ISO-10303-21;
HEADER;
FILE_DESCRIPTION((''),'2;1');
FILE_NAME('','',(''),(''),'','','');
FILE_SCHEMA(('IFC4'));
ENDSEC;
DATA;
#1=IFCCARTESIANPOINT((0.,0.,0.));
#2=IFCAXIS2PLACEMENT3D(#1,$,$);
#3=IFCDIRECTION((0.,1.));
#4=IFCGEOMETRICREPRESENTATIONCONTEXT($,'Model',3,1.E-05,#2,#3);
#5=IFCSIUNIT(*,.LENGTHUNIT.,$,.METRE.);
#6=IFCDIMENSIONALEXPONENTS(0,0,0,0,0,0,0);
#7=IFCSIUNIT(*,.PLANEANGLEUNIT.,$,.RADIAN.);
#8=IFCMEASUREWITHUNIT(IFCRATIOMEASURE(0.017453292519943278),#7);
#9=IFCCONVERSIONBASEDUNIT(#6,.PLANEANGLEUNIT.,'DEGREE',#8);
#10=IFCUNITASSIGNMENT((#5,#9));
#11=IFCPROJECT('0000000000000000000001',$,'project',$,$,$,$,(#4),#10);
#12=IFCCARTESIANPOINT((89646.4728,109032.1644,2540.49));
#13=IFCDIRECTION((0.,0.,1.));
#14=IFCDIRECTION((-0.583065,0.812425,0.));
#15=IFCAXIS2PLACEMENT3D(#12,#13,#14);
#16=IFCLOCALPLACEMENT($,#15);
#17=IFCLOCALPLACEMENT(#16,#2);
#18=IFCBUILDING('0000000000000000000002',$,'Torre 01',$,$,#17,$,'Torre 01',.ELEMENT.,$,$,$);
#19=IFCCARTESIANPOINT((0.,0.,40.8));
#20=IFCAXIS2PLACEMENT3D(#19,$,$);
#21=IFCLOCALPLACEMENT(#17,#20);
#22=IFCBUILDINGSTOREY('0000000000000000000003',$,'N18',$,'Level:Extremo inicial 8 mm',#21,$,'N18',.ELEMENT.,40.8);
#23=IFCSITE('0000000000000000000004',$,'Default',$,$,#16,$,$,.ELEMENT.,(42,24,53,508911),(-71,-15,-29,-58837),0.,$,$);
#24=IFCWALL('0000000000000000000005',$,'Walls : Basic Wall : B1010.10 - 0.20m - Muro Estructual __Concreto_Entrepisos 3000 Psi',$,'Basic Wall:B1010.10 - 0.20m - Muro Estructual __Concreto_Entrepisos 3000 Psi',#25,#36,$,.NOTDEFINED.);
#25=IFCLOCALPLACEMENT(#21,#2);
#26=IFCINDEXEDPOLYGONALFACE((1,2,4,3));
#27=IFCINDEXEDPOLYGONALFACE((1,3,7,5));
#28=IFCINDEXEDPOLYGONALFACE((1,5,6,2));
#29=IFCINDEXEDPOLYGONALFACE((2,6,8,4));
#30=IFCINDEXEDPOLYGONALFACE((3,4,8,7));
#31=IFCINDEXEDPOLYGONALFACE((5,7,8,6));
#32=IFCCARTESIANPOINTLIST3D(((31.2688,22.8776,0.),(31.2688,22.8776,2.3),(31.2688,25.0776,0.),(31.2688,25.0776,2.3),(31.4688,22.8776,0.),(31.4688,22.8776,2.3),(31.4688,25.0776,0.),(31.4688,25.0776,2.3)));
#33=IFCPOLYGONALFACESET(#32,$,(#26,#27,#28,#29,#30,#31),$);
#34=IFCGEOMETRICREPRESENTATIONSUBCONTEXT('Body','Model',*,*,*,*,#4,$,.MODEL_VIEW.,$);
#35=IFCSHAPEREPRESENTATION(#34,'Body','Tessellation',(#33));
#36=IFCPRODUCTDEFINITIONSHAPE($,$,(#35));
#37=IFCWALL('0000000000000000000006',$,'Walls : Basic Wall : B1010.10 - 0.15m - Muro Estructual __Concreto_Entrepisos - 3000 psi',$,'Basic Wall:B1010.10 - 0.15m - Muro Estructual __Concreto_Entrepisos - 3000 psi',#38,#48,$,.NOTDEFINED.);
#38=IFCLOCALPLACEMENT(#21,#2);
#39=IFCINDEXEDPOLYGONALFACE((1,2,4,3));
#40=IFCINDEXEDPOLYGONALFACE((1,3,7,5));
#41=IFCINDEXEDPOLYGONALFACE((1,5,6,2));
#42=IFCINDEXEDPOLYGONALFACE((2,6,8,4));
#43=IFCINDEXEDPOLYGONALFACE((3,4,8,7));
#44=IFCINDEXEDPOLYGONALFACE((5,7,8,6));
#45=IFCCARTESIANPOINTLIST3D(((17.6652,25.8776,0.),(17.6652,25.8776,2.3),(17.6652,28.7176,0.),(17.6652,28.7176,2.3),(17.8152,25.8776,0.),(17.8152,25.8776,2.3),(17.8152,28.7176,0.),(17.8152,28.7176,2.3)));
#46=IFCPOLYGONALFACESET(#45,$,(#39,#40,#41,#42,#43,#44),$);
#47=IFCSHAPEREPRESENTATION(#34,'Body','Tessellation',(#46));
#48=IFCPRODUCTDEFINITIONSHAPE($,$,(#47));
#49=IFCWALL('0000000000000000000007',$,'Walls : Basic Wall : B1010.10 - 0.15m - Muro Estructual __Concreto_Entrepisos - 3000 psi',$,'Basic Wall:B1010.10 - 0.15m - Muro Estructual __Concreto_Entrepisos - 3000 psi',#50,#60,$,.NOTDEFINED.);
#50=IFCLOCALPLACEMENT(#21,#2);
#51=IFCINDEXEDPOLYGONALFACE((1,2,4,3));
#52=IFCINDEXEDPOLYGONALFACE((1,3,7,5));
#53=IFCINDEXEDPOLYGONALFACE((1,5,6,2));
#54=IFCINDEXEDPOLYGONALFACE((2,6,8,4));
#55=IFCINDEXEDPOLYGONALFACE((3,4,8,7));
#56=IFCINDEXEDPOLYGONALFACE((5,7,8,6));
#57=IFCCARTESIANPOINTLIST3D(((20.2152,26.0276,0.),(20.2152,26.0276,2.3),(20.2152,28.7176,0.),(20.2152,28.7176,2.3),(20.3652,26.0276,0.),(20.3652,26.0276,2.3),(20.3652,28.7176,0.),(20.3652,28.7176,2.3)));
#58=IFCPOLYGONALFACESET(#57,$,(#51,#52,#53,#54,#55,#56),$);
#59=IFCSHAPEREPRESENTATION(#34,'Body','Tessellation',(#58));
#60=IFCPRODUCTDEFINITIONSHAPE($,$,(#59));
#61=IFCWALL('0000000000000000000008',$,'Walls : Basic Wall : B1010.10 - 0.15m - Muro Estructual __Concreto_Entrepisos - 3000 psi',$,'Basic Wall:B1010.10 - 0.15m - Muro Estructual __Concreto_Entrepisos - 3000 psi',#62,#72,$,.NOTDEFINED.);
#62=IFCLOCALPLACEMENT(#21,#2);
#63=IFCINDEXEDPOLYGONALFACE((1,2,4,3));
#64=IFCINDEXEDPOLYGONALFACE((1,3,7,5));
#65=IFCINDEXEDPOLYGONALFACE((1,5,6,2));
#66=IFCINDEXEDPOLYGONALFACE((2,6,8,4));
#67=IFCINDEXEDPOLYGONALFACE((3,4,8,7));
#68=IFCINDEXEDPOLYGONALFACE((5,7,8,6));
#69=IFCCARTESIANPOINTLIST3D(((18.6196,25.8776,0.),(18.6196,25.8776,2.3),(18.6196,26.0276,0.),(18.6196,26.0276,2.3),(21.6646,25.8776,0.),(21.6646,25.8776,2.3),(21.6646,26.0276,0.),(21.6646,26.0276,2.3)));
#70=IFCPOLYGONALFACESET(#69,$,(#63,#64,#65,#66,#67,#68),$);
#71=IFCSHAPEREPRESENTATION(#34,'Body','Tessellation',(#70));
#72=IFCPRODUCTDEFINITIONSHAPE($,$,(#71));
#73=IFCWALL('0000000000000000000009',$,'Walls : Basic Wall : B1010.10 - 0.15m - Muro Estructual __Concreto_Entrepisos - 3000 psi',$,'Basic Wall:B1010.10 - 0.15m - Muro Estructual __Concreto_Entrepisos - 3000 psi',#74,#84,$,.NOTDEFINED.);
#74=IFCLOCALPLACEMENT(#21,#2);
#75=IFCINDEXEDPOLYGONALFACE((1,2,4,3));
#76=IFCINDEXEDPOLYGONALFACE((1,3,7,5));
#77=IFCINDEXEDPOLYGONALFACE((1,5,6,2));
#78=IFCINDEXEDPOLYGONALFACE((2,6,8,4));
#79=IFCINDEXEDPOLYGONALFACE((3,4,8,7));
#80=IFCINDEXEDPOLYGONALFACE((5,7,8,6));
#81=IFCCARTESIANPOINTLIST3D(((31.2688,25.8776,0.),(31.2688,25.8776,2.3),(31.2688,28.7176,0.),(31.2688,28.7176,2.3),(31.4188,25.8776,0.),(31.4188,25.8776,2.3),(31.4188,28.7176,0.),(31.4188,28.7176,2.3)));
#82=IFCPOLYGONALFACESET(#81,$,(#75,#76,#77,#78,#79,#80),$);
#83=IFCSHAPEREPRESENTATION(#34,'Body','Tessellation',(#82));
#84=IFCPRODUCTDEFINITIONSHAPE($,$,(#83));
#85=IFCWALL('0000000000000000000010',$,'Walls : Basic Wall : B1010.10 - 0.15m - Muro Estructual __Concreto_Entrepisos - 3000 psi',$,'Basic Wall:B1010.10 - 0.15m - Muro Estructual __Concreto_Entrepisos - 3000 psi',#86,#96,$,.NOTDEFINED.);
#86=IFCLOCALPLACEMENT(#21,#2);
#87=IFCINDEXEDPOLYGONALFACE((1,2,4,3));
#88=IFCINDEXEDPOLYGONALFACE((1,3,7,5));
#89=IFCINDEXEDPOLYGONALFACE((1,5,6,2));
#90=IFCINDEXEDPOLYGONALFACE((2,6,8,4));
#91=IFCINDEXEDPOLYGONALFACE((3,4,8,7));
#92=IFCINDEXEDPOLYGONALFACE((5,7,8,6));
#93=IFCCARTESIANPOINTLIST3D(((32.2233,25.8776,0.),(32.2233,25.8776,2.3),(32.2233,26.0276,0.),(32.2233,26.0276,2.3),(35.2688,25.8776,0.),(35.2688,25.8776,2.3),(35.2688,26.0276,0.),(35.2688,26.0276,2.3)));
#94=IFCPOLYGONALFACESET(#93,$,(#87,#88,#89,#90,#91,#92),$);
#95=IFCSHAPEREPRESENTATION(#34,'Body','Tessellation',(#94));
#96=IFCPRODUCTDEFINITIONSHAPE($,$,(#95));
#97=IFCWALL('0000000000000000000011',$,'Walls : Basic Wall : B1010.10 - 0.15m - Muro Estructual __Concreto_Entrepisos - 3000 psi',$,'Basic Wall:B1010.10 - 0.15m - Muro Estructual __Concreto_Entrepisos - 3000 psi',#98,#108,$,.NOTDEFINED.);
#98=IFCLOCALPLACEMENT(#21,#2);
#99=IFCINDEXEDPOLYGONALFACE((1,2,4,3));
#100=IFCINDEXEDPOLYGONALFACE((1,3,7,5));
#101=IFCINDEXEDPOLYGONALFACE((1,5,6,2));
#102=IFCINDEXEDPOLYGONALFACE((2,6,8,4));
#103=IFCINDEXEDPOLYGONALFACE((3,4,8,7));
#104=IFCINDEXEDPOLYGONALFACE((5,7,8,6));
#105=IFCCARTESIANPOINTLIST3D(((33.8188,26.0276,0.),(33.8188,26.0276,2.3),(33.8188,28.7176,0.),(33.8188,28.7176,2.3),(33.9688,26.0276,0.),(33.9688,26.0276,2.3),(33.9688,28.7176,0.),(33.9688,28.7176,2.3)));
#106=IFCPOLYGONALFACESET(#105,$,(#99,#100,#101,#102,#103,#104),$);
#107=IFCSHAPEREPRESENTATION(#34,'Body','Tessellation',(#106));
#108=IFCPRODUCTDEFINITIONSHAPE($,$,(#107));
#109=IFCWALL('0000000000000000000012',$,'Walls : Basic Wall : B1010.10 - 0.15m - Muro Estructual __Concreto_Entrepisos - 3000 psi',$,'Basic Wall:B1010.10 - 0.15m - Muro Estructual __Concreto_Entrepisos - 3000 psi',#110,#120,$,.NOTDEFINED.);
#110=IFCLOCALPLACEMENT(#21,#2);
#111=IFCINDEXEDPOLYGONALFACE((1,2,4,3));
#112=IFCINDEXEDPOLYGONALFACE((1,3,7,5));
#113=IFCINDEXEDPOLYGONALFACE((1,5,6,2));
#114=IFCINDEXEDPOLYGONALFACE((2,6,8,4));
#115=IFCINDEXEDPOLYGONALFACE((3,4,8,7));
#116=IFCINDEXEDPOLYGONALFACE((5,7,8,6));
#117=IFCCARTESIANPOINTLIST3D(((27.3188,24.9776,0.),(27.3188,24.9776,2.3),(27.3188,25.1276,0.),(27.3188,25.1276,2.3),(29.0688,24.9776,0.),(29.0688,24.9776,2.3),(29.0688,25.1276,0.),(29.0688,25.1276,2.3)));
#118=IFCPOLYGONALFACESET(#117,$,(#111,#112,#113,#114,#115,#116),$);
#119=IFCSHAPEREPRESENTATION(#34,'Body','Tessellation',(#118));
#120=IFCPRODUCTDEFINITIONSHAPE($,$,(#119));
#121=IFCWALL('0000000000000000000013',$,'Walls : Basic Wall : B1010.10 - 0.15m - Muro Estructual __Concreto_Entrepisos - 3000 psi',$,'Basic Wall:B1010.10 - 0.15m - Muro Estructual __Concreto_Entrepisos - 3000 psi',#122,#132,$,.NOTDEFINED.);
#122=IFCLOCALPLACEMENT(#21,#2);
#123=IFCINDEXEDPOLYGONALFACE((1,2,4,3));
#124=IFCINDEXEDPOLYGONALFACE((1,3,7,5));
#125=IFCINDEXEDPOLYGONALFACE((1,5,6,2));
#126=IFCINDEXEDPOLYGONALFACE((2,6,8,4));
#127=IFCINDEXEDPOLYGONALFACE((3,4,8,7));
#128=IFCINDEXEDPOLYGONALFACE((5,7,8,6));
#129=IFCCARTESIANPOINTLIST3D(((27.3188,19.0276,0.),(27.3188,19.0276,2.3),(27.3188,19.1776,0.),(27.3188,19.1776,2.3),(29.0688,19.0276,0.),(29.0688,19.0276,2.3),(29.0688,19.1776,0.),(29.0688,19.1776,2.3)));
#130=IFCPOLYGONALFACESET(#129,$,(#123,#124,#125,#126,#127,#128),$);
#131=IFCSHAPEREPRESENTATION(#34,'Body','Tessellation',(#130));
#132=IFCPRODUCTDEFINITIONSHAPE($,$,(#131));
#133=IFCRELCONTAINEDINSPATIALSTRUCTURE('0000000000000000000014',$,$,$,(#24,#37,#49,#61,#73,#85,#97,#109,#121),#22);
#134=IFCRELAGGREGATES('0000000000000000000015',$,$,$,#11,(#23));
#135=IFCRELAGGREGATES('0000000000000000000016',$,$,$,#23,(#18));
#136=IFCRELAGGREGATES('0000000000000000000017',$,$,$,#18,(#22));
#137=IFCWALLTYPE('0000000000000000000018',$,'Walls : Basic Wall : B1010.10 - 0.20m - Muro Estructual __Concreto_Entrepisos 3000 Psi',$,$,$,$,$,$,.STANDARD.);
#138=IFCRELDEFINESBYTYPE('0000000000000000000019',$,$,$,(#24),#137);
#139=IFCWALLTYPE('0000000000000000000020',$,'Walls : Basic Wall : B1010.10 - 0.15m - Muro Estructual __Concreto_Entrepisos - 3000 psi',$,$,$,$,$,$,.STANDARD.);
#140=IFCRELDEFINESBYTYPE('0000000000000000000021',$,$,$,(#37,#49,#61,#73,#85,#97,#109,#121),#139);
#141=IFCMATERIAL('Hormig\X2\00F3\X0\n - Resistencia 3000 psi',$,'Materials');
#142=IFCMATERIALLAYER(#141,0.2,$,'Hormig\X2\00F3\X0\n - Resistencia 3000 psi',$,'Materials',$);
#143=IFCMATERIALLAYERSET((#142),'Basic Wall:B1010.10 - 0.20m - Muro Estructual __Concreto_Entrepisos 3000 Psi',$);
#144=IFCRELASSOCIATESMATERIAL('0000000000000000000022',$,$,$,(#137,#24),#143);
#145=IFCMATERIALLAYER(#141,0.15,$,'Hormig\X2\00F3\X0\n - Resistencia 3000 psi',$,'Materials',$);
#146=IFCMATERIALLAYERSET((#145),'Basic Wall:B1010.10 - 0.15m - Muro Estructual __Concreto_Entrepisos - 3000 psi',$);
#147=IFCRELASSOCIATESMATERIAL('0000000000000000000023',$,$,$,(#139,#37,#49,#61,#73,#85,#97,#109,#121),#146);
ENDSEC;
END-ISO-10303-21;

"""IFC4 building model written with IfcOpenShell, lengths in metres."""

from ifc_helpers import new_model, entity, si_unit, converted_unit, direction, frame, frame_2d, origin, place, context, subcontext, project, spatial, rectangle, extrude, material, layer, layer_set, layer_usage, type_object, element, save


model = new_model("IFC4")

# Units and contexts
model_context = context("Model", 3, precision=1e-05, world=origin(), true_north=direction((0.0, 1.0)))
body_context = subcontext(model_context, "Body", "Model", "MODEL_VIEW")
ifc_project = project(units=[si_unit("LENGTHUNIT", "METRE"), converted_unit("PLANEANGLEUNIT", "DEGREE", entity("IfcRatioMeasure", 0.017453292519943278), si_unit("PLANEANGLEUNIT", "RADIAN"), dimensions=[0, 0, 0, 0, 0, 0, 0])], contexts=[model_context])

# Site, building, storey
site_placement = place(None, frame((89646.4728, 109032.1644, 2540.49), z_axis=(0.0, 0.0, 1.0), x_axis=(-0.583065, 0.812425, 0.0)))
site = spatial("IfcSite", under=ifc_project, at=site_placement, Name="Default", CompositionType="ELEMENT", RefLatitude=(42, 24, 53, 508911), RefLongitude=(-71, -15, -29, -58837), RefElevation=0.0)
building_placement = place(site_placement, origin())
building = spatial("IfcBuilding", under=site, at=building_placement, Name="Torre 01", LongName="Torre 01", CompositionType="ELEMENT")
storey_placement = place(building_placement, frame((0.0, 0.0, 40.8)))
storey = spatial("IfcBuildingStorey", under=building, at=storey_placement, Name="N18", ObjectType="Level:Extremo inicial 8 mm", LongName="N18", CompositionType="ELEMENT", Elevation=40.8)

# Walls
ifc_material = material(Name="Hormigón - Resistencia 3000 psi", Category="Materials")
ifc_layer_1 = layer(ifc_material, 0.2, Name="Hormigón - Resistencia 3000 psi", Category="Materials")
ifc_layer_set_1 = layer_set([ifc_layer_1], Name="Basic Wall:B1010.10 - 0.20m - Muro Estructual __Concreto_Entrepisos 3000 Psi")
wall_type_1 = type_object("IfcWallType", Name="Walls : Basic Wall : B1010.10 - 0.20m - Muro Estructual __Concreto_Entrepisos 3000 Psi", PredefinedType="STANDARD", material=ifc_layer_set_1)
ifc_layer_usage_1 = layer_usage(ifc_layer_set_1, "AXIS2", "POSITIVE", -0.1)
wall_1_placement = place(storey_placement, frame((31.3688, 22.8776, 0.0), z_axis=(0.0, 0.0, 1.0), x_axis=(0.0, 1.0, 0.0)))
element("IfcWall", 1, at=wall_1_placement, inside=storey, type_object=wall_type_1, material=ifc_layer_usage_1, Name="Walls : Basic Wall : B1010.10 - 0.20m - Muro Estructual __Concreto_Entrepisos 3000 Psi", ObjectType="Basic Wall:B1010.10 - 0.20m - Muro Estructual __Concreto_Entrepisos 3000 Psi", PredefinedType="NOTDEFINED", context=body_context, shape_type="SweptSolid", body=[
    extrude(rectangle(XDim=2.2, YDim=0.2, at=frame_2d((1.1, 0.0), x_axis=(-1.0, 0.0))), origin(), (0.0, 0.0, 1.0), 2.3),
])
ifc_layer_2 = layer(ifc_material, 0.15, Name="Hormigón - Resistencia 3000 psi", Category="Materials")
ifc_layer_set_2 = layer_set([ifc_layer_2], Name="Basic Wall:B1010.10 - 0.15m - Muro Estructual __Concreto_Entrepisos - 3000 psi")
ifc_layer_usage_2 = layer_usage(ifc_layer_set_2, "AXIS2", "POSITIVE", -0.075)
wall_type_2 = type_object("IfcWallType", Name="Walls : Basic Wall : B1010.10 - 0.15m - Muro Estructual __Concreto_Entrepisos - 3000 psi", PredefinedType="STANDARD", material=ifc_layer_set_2)
wall_2_placement = place(storey_placement, frame((17.7402, 25.8776, 0.0), z_axis=(0.0, 0.0, 1.0), x_axis=(0.0, 1.0, 0.0)))
element("IfcWall", 2, at=wall_2_placement, inside=storey, type_object=wall_type_2, material=ifc_layer_usage_2, Name="Walls : Basic Wall : B1010.10 - 0.15m - Muro Estructual __Concreto_Entrepisos - 3000 psi", ObjectType="Basic Wall:B1010.10 - 0.15m - Muro Estructual __Concreto_Entrepisos - 3000 psi", PredefinedType="NOTDEFINED", context=body_context, shape_type="SweptSolid", body=[
    extrude(rectangle(XDim=2.84, YDim=0.15, at=frame_2d((1.42, 0.0), x_axis=(-1.0, 0.0))), origin(), (0.0, 0.0, 1.0), 2.3),
])
ifc_layer_usage_3 = layer_usage(ifc_layer_set_2, "AXIS2", "POSITIVE", -0.075)
wall_3_placement = place(storey_placement, frame((20.2902, 28.7176, 0.0), z_axis=(0.0, 0.0, 1.0), x_axis=(0.0, -1.0, 0.0)))
element("IfcWall", 3, at=wall_3_placement, inside=storey, type_object=wall_type_2, material=ifc_layer_usage_3, Name="Walls : Basic Wall : B1010.10 - 0.15m - Muro Estructual __Concreto_Entrepisos - 3000 psi", ObjectType="Basic Wall:B1010.10 - 0.15m - Muro Estructual __Concreto_Entrepisos - 3000 psi", PredefinedType="NOTDEFINED", context=body_context, shape_type="SweptSolid", body=[
    extrude(rectangle(XDim=2.69, YDim=0.15, at=frame_2d((1.345, 0.0), x_axis=(-1.0, 0.0))), origin(), (0.0, 0.0, 1.0), 2.3),
])
ifc_layer_usage_4 = layer_usage(ifc_layer_set_2, "AXIS2", "POSITIVE", -0.075)
wall_4_placement = place(storey_placement, frame((18.6196, 25.9526, 0.0)))
element("IfcWall", 4, at=wall_4_placement, inside=storey, type_object=wall_type_2, material=ifc_layer_usage_4, Name="Walls : Basic Wall : B1010.10 - 0.15m - Muro Estructual __Concreto_Entrepisos - 3000 psi", ObjectType="Basic Wall:B1010.10 - 0.15m - Muro Estructual __Concreto_Entrepisos - 3000 psi", PredefinedType="NOTDEFINED", context=body_context, shape_type="SweptSolid", body=[
    extrude(rectangle(XDim=3.045, YDim=0.15, at=frame_2d((1.5225, 0.0), x_axis=(-1.0, 0.0))), origin(), (0.0, 0.0, 1.0), 2.3),
])
ifc_layer_usage_5 = layer_usage(ifc_layer_set_2, "AXIS2", "POSITIVE", -0.075)
wall_5_placement = place(storey_placement, frame((31.3438, 28.7176, 0.0), z_axis=(0.0, 0.0, 1.0), x_axis=(0.0, -1.0, 0.0)))
element("IfcWall", 5, at=wall_5_placement, inside=storey, type_object=wall_type_2, material=ifc_layer_usage_5, Name="Walls : Basic Wall : B1010.10 - 0.15m - Muro Estructual __Concreto_Entrepisos - 3000 psi", ObjectType="Basic Wall:B1010.10 - 0.15m - Muro Estructual __Concreto_Entrepisos - 3000 psi", PredefinedType="NOTDEFINED", context=body_context, shape_type="SweptSolid", body=[
    extrude(rectangle(XDim=2.84, YDim=0.15, at=frame_2d((1.42, 0.0), x_axis=(-1.0, 0.0))), origin(), (0.0, 0.0, 1.0), 2.3),
])
ifc_layer_usage_6 = layer_usage(ifc_layer_set_2, "AXIS2", "POSITIVE", -0.075)
wall_6_placement = place(storey_placement, frame((32.2233, 25.9526, 0.0)))
element("IfcWall", 6, at=wall_6_placement, inside=storey, type_object=wall_type_2, material=ifc_layer_usage_6, Name="Walls : Basic Wall : B1010.10 - 0.15m - Muro Estructual __Concreto_Entrepisos - 3000 psi", ObjectType="Basic Wall:B1010.10 - 0.15m - Muro Estructual __Concreto_Entrepisos - 3000 psi", PredefinedType="NOTDEFINED", context=body_context, shape_type="SweptSolid", body=[
    extrude(rectangle(XDim=3.0455, YDim=0.15, at=frame_2d((1.5228, 0.0), x_axis=(-1.0, 0.0))), origin(), (0.0, 0.0, 1.0), 2.3),
])
ifc_layer_usage_7 = layer_usage(ifc_layer_set_2, "AXIS2", "POSITIVE", -0.075)
wall_7_placement = place(storey_placement, frame((33.8938, 26.0276, 0.0), z_axis=(0.0, 0.0, 1.0), x_axis=(0.0, 1.0, 0.0)))
element("IfcWall", 7, at=wall_7_placement, inside=storey, type_object=wall_type_2, material=ifc_layer_usage_7, Name="Walls : Basic Wall : B1010.10 - 0.15m - Muro Estructual __Concreto_Entrepisos - 3000 psi", ObjectType="Basic Wall:B1010.10 - 0.15m - Muro Estructual __Concreto_Entrepisos - 3000 psi", PredefinedType="NOTDEFINED", context=body_context, shape_type="SweptSolid", body=[
    extrude(rectangle(XDim=2.69, YDim=0.15, at=frame_2d((1.345, 0.0), x_axis=(-1.0, 0.0))), origin(), (0.0, 0.0, 1.0), 2.3),
])
ifc_layer_usage_8 = layer_usage(ifc_layer_set_2, "AXIS2", "NEGATIVE", 0.075)
wall_8_placement = place(storey_placement, frame((29.0688, 25.0526, 0.0), z_axis=(0.0, 0.0, 1.0), x_axis=(-1.0, 0.0, 0.0)))
element("IfcWall", 8, at=wall_8_placement, inside=storey, type_object=wall_type_2, material=ifc_layer_usage_8, Name="Walls : Basic Wall : B1010.10 - 0.15m - Muro Estructual __Concreto_Entrepisos - 3000 psi", ObjectType="Basic Wall:B1010.10 - 0.15m - Muro Estructual __Concreto_Entrepisos - 3000 psi", PredefinedType="NOTDEFINED", context=body_context, shape_type="SweptSolid", body=[
    extrude(rectangle(XDim=1.75, YDim=0.15, at=frame_2d((0.875, 0.0), x_axis=(-1.0, 0.0))), origin(), (0.0, 0.0, 1.0), 2.3),
])
ifc_layer_usage_9 = layer_usage(ifc_layer_set_2, "AXIS2", "POSITIVE", -0.075)
wall_9_placement = place(storey_placement, frame((29.0688, 19.1026, 0.0), z_axis=(0.0, 0.0, 1.0), x_axis=(-1.0, 0.0, 0.0)))
element("IfcWall", 9, at=wall_9_placement, inside=storey, type_object=wall_type_2, material=ifc_layer_usage_9, Name="Walls : Basic Wall : B1010.10 - 0.15m - Muro Estructual __Concreto_Entrepisos - 3000 psi", ObjectType="Basic Wall:B1010.10 - 0.15m - Muro Estructual __Concreto_Entrepisos - 3000 psi", PredefinedType="NOTDEFINED", context=body_context, shape_type="SweptSolid", body=[
    extrude(rectangle(XDim=1.75, YDim=0.15, at=frame_2d((0.875, 0.0), x_axis=(-1.0, 0.0))), origin(), (0.0, 0.0, 1.0), 2.3),
])

save(model, "model.ifc")
